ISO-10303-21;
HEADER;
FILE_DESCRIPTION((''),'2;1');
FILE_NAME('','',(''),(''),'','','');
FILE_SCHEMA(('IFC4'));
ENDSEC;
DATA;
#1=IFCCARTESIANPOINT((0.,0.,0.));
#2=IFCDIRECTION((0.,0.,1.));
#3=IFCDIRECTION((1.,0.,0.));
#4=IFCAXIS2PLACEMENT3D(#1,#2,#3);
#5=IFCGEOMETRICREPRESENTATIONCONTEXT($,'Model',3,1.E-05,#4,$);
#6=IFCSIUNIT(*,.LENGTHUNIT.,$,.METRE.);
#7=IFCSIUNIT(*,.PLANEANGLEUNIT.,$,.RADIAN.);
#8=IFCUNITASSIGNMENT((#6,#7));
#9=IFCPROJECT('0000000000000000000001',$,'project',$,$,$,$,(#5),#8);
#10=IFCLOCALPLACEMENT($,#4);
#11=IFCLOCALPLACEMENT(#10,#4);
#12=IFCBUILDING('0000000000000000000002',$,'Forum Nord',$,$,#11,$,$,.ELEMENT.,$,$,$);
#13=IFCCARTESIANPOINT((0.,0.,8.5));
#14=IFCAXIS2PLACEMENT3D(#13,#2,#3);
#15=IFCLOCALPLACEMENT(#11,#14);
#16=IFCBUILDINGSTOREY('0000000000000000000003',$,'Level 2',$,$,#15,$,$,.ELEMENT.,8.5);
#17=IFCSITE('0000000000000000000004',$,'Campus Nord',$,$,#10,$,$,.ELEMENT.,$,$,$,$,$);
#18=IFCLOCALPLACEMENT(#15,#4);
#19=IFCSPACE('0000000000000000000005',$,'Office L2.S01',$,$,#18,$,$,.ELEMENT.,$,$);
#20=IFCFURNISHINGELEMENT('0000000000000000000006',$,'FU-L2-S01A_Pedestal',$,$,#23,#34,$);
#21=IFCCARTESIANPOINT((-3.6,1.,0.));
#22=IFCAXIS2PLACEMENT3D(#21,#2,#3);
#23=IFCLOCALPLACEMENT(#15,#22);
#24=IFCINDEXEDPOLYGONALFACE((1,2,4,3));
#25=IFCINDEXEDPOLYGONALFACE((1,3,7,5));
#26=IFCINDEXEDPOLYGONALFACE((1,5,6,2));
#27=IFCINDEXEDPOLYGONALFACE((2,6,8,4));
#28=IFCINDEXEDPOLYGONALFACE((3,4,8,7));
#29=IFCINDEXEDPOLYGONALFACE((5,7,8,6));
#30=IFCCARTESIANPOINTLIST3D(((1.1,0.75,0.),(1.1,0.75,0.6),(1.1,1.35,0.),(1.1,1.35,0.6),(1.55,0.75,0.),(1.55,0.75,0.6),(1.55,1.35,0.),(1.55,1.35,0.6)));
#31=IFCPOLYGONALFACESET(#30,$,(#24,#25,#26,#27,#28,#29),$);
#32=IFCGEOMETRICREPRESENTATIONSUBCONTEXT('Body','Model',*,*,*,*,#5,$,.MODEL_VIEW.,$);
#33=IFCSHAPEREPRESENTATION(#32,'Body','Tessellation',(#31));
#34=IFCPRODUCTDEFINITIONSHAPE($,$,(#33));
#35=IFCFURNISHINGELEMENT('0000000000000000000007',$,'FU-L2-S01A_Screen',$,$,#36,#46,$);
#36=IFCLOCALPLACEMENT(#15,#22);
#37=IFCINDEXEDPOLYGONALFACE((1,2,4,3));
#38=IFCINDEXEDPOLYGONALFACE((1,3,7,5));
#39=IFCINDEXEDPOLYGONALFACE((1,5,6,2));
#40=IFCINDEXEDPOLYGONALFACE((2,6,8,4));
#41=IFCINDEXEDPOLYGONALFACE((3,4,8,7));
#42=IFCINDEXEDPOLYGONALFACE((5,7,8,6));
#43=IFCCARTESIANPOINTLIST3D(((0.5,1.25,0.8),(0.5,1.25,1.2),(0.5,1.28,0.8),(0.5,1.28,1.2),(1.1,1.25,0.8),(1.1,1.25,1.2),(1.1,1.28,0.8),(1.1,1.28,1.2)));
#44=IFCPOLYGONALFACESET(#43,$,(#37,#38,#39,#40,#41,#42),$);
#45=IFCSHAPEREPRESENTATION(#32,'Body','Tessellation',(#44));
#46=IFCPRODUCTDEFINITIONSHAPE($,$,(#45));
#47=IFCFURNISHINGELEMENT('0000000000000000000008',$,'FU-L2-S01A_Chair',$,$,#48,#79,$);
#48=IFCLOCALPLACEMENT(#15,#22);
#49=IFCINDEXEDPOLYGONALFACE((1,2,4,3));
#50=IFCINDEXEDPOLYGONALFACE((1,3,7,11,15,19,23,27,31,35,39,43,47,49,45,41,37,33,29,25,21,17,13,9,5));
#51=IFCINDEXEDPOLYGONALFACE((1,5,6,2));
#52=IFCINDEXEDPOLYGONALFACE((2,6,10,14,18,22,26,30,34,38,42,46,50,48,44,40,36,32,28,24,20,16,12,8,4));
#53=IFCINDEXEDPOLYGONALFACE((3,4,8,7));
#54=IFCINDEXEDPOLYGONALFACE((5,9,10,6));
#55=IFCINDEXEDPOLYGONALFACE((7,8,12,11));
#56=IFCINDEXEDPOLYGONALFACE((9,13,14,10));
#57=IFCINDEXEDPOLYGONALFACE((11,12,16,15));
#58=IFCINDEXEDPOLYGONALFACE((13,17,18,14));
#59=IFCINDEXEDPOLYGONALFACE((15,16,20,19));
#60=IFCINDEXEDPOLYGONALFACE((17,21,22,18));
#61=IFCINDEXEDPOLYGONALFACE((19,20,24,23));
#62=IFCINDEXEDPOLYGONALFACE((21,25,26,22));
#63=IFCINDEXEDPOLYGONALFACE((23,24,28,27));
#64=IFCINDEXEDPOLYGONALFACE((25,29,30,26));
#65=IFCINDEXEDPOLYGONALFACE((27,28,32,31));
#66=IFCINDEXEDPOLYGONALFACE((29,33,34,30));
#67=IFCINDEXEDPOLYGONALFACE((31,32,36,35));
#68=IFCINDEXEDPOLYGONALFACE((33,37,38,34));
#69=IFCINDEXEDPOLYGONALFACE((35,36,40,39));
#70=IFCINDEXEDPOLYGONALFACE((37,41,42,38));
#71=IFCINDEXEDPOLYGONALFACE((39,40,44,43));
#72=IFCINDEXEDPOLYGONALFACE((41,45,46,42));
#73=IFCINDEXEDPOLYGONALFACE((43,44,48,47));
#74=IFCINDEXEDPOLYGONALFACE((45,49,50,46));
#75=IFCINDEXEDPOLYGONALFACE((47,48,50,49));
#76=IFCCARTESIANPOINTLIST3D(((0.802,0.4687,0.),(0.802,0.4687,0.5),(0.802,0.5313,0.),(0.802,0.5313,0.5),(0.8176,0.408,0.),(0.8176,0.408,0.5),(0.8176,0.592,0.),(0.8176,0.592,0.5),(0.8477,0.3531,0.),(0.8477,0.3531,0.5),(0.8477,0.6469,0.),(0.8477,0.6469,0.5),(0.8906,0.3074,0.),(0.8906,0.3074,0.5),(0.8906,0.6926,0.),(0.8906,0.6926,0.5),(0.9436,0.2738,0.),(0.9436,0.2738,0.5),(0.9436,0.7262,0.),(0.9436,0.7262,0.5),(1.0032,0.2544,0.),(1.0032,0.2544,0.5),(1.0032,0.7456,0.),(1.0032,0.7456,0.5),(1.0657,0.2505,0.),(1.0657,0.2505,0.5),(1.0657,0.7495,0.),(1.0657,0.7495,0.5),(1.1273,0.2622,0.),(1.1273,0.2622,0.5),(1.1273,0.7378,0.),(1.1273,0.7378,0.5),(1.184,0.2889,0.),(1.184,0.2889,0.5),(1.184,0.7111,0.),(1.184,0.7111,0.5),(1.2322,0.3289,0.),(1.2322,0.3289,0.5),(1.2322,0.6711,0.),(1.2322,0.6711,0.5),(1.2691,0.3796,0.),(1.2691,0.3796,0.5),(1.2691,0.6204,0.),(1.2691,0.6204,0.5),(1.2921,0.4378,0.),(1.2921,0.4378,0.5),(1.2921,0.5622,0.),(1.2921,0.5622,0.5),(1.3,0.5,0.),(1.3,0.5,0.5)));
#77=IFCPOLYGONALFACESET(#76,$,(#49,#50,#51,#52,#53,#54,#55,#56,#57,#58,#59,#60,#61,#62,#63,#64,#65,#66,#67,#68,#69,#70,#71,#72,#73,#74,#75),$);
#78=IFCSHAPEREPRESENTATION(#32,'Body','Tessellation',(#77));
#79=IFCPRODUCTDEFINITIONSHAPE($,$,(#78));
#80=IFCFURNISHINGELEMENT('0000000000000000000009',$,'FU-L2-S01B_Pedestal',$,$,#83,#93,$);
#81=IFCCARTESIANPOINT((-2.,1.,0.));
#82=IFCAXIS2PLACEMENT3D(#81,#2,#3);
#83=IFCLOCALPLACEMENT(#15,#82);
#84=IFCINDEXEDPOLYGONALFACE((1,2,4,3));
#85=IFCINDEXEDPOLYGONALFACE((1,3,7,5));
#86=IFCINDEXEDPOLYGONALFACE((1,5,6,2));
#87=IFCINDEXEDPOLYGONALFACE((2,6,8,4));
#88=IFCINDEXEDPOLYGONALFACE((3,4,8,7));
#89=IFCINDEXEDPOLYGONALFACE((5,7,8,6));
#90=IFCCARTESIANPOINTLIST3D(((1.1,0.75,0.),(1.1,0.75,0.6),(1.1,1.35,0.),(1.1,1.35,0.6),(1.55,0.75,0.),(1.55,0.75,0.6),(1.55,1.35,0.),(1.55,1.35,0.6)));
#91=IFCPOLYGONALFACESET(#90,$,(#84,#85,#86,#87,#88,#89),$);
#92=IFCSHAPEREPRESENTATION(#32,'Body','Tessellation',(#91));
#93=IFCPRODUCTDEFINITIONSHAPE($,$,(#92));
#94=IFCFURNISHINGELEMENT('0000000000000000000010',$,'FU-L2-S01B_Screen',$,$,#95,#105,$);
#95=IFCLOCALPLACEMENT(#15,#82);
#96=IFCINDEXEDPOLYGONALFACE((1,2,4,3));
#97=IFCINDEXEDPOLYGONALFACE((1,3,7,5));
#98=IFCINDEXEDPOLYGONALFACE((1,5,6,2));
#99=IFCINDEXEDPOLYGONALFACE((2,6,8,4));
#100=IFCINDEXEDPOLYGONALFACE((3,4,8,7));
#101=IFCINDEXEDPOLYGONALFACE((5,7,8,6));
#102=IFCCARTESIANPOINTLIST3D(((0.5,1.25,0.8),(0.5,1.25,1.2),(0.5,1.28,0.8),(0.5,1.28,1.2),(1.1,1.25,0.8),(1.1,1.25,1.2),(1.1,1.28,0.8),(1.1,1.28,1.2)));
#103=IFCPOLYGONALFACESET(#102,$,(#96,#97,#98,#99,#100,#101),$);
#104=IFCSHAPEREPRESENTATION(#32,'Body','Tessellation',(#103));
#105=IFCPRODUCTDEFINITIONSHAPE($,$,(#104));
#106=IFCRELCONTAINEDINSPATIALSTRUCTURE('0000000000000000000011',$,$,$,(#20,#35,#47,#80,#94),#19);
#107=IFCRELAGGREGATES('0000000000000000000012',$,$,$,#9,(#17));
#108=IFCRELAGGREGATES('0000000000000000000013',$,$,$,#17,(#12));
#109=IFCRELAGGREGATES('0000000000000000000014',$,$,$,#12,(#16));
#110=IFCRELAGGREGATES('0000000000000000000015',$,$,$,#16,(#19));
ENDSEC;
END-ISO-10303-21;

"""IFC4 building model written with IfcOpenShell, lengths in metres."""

from ifc_helpers import new_model, si_unit, frame, frame_2d, origin_with_axes, place, context, subcontext, project, spatial, rectangle, circle, extrude, element, save


model = new_model("IFC4")

# Units and contexts
model_context = context("Model", 3, precision=1e-05, world=origin_with_axes())
body_context = subcontext(model_context, "Body", "Model", "MODEL_VIEW")
ifc_project = project(units=[si_unit("LENGTHUNIT", "METRE"), si_unit("PLANEANGLEUNIT", "RADIAN")], contexts=[model_context])

# Site, building, storey
site_placement = place(None, origin_with_axes())
site = spatial("IfcSite", under=ifc_project, at=site_placement, Name="Campus Nord", CompositionType="ELEMENT")
building_placement = place(site_placement, origin_with_axes())
building = spatial("IfcBuilding", under=site, at=building_placement, Name="Forum Nord", CompositionType="ELEMENT")
storey_placement = place(building_placement, frame((0.0, 0.0, 8.5), z_axis=(0.0, 0.0, 1.0), x_axis=(1.0, 0.0, 0.0)))
storey = spatial("IfcBuildingStorey", under=building, at=storey_placement, Name="Level 2", CompositionType="ELEMENT", Elevation=8.5)

# Shared definitions
space_placement = place(storey_placement, origin_with_axes())
space = spatial("IfcSpace", under=storey, at=space_placement, Name="Office L2.S01", CompositionType="ELEMENT")

# Furnishing elements
furnishing_1_placement = place(storey_placement, frame((-3.6, 1.0, 0.0), z_axis=(0.0, 0.0, 1.0), x_axis=(1.0, 0.0, 0.0)))
element("IfcFurnishingElement", 1, at=furnishing_1_placement, inside=space, Name="FU-L2-S01A_Pedestal", context=body_context, shape_type="SweptSolid", body=[
    extrude(rectangle(XDim=0.45, YDim=0.6, at=frame_2d((1.325, 1.05), x_axis=(1.0, 0.0))), origin_with_axes(), (0.0, 0.0, 1.0), 0.6),
])
furnishing_2_placement = place(storey_placement, frame((-3.6, 1.0, 0.0), z_axis=(0.0, 0.0, 1.0), x_axis=(1.0, 0.0, 0.0)))
element("IfcFurnishingElement", 2, at=furnishing_2_placement, inside=space, Name="FU-L2-S01A_Screen", context=body_context, shape_type="SweptSolid", body=[
    extrude(rectangle(XDim=0.6, YDim=0.03, at=frame_2d((0.8, 1.265), x_axis=(1.0, 0.0))), frame((0.0, 0.0, 0.8), z_axis=(0.0, 0.0, 1.0), x_axis=(1.0, 0.0, 0.0)), (0.0, 0.0, 1.0), 0.4),
])
furnishing_3_placement = place(storey_placement, frame((-3.6, 1.0, 0.0), z_axis=(0.0, 0.0, 1.0), x_axis=(1.0, 0.0, 0.0)))
element("IfcFurnishingElement", 3, at=furnishing_3_placement, inside=space, Name="FU-L2-S01A_Chair", context=body_context, shape_type="SweptSolid", body=[
    extrude(circle(Radius=0.25, at=frame_2d((1.05, 0.5), x_axis=(1.0, 0.0))), origin_with_axes(), (0.0, 0.0, 1.0), 0.5),
])
furnishing_4_placement = place(storey_placement, frame((-2.0, 1.0, 0.0), z_axis=(0.0, 0.0, 1.0), x_axis=(1.0, 0.0, 0.0)))
element("IfcFurnishingElement", 4, at=furnishing_4_placement, inside=space, Name="FU-L2-S01B_Pedestal", context=body_context, shape_type="SweptSolid", body=[
    extrude(rectangle(XDim=0.45, YDim=0.6, at=frame_2d((1.325, 1.05), x_axis=(1.0, 0.0))), origin_with_axes(), (0.0, 0.0, 1.0), 0.6),
])
furnishing_5_placement = place(storey_placement, frame((-2.0, 1.0, 0.0), z_axis=(0.0, 0.0, 1.0), x_axis=(1.0, 0.0, 0.0)))
element("IfcFurnishingElement", 5, at=furnishing_5_placement, inside=space, Name="FU-L2-S01B_Screen", context=body_context, shape_type="SweptSolid", body=[
    extrude(rectangle(XDim=0.6, YDim=0.03, at=frame_2d((0.8, 1.265), x_axis=(1.0, 0.0))), frame((0.0, 0.0, 0.8), z_axis=(0.0, 0.0, 1.0), x_axis=(1.0, 0.0, 0.0)), (0.0, 0.0, 1.0), 0.4),
])

save(model, "model.ifc")
